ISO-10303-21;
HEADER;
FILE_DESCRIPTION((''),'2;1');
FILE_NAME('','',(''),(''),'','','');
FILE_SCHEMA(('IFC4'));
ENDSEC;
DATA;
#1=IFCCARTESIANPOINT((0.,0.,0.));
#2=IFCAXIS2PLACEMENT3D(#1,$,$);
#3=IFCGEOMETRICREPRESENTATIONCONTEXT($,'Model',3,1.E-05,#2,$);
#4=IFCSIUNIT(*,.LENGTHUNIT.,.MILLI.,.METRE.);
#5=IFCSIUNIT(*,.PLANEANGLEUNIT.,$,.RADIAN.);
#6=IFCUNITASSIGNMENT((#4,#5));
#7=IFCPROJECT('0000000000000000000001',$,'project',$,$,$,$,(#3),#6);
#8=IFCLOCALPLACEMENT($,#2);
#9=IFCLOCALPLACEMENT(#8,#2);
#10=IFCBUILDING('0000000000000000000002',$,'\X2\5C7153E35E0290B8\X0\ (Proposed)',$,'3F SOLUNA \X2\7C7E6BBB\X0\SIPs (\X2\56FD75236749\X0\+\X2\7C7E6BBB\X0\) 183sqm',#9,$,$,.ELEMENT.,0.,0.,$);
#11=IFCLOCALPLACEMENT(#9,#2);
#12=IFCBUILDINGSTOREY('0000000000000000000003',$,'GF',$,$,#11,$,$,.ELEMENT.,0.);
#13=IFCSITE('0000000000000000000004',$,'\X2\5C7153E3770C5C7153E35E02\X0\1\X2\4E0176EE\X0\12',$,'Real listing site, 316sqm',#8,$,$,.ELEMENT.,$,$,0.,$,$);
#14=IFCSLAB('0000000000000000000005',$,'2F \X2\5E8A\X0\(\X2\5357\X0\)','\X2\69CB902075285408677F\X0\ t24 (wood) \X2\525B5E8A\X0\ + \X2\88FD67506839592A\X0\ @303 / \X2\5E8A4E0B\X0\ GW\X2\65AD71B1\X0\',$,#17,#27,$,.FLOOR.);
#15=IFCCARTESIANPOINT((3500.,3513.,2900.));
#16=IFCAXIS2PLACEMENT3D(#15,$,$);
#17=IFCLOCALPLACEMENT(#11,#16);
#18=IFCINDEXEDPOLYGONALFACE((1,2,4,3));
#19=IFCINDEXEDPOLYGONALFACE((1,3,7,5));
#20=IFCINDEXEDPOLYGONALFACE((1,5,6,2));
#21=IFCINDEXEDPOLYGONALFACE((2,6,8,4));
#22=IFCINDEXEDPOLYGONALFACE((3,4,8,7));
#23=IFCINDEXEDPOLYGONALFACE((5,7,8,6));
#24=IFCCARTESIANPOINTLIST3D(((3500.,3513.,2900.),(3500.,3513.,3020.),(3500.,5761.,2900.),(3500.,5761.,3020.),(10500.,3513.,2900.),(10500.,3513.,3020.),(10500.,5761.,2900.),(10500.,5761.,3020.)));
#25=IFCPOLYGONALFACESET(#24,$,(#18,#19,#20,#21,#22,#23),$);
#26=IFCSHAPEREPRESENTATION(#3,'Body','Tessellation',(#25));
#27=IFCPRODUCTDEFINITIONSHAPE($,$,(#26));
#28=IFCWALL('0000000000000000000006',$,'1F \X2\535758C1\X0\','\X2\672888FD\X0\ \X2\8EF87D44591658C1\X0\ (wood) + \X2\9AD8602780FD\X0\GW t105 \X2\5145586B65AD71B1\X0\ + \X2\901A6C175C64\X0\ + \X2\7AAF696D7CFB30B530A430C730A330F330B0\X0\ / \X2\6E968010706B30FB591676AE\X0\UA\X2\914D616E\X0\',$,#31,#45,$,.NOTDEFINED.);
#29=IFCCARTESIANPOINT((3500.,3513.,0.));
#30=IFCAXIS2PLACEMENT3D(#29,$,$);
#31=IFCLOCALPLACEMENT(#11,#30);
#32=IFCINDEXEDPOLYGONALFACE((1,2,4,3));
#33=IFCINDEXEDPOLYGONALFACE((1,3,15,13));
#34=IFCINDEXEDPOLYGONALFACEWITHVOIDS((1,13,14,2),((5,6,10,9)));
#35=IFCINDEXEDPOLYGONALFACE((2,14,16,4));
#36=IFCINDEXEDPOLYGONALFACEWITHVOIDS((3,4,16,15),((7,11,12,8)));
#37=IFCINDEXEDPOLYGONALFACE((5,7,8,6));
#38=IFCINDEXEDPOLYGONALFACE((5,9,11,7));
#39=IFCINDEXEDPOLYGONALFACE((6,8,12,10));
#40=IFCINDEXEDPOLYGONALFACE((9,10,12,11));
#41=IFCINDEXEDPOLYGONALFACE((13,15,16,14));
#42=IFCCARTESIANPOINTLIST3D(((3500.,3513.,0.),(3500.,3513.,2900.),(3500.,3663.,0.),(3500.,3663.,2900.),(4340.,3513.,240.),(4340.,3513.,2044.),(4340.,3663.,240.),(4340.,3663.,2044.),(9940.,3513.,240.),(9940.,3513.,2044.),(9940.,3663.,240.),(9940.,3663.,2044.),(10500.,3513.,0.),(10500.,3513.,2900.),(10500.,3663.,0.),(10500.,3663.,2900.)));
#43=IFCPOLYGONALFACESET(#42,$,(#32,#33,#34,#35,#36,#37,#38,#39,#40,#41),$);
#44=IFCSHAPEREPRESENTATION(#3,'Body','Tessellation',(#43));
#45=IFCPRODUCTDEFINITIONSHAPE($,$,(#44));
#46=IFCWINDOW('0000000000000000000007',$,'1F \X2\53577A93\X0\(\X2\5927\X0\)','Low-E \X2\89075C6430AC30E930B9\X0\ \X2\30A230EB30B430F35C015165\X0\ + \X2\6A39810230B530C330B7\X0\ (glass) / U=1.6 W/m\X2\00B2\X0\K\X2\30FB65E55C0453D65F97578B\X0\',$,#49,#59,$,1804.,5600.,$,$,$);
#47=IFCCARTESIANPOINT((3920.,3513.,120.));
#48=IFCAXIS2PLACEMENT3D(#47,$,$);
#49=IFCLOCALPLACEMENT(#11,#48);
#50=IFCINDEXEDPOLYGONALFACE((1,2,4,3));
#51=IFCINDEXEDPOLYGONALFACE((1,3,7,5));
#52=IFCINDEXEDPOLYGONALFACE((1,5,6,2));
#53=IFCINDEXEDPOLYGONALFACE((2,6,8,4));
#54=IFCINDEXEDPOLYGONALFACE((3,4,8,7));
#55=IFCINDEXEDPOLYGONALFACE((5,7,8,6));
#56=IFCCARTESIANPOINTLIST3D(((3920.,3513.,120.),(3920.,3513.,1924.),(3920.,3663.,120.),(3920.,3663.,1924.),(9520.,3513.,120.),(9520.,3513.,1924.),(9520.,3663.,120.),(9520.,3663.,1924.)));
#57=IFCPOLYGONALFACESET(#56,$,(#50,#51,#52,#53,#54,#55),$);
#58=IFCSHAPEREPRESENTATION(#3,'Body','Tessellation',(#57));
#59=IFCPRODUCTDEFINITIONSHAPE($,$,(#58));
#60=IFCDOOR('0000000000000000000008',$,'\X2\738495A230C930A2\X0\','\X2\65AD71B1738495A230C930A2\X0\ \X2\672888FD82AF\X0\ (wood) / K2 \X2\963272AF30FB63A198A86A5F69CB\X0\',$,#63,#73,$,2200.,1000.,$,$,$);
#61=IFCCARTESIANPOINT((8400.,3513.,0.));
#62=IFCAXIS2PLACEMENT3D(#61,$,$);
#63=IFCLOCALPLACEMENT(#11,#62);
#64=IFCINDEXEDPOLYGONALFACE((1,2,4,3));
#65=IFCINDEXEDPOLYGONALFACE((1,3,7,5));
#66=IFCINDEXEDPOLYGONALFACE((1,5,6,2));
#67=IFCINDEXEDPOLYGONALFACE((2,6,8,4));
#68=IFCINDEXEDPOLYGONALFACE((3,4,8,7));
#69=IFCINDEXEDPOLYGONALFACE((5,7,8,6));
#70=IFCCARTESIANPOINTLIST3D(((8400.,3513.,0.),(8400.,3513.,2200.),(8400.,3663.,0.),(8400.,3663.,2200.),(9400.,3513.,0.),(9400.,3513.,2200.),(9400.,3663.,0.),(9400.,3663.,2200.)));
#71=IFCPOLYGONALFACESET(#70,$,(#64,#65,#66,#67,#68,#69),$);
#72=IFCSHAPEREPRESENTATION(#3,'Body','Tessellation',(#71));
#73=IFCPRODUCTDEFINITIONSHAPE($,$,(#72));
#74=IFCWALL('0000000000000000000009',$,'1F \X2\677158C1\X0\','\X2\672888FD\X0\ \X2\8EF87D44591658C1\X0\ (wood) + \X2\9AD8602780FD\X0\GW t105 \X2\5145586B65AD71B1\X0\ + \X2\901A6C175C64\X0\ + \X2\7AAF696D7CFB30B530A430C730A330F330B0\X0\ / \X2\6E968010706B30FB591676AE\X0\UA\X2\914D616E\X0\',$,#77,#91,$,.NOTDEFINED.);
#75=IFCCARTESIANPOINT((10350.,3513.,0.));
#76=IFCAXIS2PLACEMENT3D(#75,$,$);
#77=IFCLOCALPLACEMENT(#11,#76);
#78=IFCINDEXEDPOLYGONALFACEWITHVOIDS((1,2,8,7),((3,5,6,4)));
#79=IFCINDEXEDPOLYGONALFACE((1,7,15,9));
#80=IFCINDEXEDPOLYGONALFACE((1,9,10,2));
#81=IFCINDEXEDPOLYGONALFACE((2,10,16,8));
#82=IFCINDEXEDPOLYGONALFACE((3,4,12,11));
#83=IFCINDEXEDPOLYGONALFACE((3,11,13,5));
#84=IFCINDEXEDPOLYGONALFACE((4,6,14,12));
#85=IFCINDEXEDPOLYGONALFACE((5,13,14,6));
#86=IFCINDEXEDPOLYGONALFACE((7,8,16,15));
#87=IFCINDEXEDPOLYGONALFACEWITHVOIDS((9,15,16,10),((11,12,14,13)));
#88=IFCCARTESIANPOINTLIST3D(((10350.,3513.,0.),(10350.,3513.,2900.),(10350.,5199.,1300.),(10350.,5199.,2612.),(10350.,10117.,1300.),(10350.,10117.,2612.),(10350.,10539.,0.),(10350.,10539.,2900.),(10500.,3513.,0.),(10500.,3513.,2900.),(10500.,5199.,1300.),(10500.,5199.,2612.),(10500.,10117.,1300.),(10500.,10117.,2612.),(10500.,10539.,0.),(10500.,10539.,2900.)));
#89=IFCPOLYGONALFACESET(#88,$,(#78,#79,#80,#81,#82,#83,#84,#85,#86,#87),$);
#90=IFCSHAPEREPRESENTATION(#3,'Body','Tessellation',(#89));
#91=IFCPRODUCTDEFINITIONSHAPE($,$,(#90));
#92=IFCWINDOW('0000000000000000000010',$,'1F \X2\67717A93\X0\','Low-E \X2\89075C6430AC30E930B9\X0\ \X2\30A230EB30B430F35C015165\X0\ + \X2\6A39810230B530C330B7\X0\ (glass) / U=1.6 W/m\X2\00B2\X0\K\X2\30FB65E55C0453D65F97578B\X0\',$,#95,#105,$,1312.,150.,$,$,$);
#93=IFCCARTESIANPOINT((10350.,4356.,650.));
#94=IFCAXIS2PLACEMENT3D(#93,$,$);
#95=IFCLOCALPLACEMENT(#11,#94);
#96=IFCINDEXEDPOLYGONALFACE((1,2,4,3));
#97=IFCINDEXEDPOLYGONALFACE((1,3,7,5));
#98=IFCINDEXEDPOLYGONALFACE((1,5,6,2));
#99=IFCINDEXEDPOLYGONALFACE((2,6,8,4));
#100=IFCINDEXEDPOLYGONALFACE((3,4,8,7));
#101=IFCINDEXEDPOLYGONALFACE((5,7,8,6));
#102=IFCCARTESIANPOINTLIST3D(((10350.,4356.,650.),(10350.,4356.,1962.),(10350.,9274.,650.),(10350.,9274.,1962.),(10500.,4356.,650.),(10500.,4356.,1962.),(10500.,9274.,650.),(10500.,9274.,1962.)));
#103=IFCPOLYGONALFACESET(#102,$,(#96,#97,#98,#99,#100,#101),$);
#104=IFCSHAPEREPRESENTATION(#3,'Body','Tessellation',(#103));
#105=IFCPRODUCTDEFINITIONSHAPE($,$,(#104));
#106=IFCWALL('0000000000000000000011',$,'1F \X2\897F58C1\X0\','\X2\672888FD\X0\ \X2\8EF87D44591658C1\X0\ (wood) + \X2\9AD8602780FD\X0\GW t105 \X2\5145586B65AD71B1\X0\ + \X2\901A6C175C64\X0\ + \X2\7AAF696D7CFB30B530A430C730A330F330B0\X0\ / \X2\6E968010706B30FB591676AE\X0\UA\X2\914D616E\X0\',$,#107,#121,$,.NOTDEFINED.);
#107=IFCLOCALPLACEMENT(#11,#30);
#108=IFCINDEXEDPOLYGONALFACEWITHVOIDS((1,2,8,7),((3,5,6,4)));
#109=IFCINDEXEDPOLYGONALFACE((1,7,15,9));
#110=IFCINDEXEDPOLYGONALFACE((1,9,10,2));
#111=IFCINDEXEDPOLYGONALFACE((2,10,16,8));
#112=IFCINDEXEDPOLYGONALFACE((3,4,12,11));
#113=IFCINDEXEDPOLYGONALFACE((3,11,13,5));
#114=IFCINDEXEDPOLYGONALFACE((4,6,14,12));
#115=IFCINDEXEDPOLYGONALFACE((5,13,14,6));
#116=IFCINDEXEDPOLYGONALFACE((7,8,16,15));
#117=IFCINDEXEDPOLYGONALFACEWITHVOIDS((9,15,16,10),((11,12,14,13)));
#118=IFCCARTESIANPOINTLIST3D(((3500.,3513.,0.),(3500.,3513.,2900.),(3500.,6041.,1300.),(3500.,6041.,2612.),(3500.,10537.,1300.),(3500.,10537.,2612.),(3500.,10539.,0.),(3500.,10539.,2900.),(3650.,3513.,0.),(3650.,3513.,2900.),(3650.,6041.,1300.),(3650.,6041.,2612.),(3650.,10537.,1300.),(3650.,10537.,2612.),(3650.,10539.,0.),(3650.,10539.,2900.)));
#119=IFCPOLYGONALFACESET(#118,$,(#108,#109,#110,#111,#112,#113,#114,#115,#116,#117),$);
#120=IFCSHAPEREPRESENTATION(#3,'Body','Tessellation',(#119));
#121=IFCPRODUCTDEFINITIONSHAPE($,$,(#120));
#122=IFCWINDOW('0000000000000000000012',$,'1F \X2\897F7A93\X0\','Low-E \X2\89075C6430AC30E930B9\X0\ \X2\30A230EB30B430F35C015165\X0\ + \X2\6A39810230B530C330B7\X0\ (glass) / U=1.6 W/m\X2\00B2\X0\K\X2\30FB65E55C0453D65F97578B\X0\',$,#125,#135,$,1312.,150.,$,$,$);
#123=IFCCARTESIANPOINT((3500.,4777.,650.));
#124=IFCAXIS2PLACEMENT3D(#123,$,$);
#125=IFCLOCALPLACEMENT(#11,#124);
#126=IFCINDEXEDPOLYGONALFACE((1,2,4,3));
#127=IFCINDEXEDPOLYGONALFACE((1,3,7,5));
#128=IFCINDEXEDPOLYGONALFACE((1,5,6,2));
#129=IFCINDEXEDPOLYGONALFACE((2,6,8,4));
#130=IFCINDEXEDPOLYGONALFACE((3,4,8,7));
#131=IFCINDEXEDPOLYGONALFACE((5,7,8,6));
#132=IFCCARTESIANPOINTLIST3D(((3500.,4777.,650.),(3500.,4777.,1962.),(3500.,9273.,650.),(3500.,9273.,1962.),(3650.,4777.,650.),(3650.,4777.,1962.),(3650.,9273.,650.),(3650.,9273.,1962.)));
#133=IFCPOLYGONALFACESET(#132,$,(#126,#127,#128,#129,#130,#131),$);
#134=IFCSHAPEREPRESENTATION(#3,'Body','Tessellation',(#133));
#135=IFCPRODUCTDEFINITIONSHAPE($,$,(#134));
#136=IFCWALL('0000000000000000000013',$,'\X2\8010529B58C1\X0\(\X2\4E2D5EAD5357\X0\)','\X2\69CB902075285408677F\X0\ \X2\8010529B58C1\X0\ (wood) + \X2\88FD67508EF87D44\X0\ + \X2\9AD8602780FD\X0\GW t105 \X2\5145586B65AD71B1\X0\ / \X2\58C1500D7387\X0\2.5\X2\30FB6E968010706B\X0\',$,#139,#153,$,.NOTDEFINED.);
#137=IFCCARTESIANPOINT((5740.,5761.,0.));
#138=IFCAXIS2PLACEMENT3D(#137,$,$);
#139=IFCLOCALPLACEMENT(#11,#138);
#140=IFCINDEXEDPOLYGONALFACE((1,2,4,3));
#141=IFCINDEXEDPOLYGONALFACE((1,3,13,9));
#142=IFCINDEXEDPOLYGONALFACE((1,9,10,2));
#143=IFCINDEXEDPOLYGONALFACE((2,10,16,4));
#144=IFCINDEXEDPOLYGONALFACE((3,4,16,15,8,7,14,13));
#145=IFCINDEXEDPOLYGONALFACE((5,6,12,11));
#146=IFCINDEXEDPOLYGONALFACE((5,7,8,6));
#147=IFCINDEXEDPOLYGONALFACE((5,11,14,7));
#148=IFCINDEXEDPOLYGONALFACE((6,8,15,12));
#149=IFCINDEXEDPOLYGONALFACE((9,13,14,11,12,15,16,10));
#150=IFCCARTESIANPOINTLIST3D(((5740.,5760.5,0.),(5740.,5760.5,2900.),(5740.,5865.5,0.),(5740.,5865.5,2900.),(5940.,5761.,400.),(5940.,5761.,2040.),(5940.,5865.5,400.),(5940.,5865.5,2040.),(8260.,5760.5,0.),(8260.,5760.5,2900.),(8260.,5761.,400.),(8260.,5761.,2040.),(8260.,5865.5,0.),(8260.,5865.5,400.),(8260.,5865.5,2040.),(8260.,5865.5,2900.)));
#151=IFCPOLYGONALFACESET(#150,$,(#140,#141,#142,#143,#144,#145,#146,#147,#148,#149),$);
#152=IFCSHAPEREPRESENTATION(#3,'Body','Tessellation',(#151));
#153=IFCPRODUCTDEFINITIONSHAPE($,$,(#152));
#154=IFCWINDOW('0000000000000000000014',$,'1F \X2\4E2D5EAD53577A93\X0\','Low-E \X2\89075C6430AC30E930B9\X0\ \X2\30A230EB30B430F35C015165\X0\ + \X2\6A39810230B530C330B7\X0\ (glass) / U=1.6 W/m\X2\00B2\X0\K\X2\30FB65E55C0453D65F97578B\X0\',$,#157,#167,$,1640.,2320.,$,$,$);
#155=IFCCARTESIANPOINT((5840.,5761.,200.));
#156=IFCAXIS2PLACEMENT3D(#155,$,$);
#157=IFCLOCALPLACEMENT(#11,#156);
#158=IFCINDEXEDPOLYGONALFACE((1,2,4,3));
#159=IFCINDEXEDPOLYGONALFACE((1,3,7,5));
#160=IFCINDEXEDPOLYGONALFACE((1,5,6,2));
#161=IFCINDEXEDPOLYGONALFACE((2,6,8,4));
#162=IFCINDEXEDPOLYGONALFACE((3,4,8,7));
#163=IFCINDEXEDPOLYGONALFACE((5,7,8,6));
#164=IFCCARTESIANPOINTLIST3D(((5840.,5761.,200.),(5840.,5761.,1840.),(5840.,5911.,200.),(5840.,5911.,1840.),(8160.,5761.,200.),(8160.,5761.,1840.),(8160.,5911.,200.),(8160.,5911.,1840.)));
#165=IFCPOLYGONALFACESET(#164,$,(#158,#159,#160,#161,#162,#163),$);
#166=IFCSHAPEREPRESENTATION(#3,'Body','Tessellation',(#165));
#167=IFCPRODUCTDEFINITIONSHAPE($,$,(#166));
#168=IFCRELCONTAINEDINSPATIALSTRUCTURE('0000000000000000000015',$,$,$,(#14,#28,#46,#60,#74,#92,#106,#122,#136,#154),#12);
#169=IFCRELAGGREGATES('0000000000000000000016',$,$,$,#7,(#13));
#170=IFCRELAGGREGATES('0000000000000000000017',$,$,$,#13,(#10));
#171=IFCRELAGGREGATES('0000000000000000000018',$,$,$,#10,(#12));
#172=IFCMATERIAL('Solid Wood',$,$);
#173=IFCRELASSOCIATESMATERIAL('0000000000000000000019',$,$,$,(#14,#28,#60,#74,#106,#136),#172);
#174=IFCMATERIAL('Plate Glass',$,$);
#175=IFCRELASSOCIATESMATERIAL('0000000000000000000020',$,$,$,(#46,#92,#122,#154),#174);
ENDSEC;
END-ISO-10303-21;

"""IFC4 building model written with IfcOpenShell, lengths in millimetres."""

from ifc_helpers import new_model, si_unit, frame, frame_2d, origin, place, context, project, spatial, rectangle, extrude, material, element, fill, save


model = new_model("IFC4")

# Units and contexts
model_context = context("Model", 3, precision=1e-05, world=origin())
ifc_project = project(units=[si_unit("LENGTHUNIT", "METRE", prefix="MILLI"), si_unit("PLANEANGLEUNIT", "RADIAN")], contexts=[model_context])

# Site, building, storey
site_placement = place(None, origin())
site = spatial("IfcSite", under=ifc_project, at=site_placement, Name="山口県山口市1丁目12", ObjectType="Real listing site, 316sqm", CompositionType="ELEMENT", RefElevation=0.0)
building_placement = place(site_placement, origin())
building = spatial("IfcBuilding", under=site, at=building_placement, Name="山口市邸 (Proposed)", ObjectType="3F SOLUNA 籾殻SIPs (国産杉+籾殻) 183sqm", CompositionType="ELEMENT", ElevationOfRefHeight=0.0, ElevationOfTerrain=0.0)
storey_placement = place(building_placement, origin())
storey = spatial("IfcBuildingStorey", under=building, at=storey_placement, Name="GF", CompositionType="ELEMENT", Elevation=0.0)

# Slab
ifc_material_1 = material(Name="Solid Wood")
slab_1_placement = place(storey_placement, frame((3500.0, 3513.0, 2900.0)))
element("IfcSlab", 1, at=slab_1_placement, inside=storey, material=ifc_material_1, Name="2F 床(南)", Description="構造用合板 t24 (wood) 剛床 + 製材根太 @303 / 床下 GW断熱", PredefinedType="FLOOR", context=model_context, shape_type="SweptSolid", body=[
    extrude(rectangle(XDim=7000.0, YDim=2248.0, at=frame_2d((3500.0, 1124.0))), frame((3500.0, 3513.0, 2900.0)), (0.0, 0.0, 1.0), 120.0),
])

# Wall, openings, window, door
wall_1_placement = place(storey_placement, frame((3500.0, 3513.0, 0.0)))
wall_1 = element("IfcWall", 2, at=wall_1_placement, inside=storey, material=ifc_material_1, Name="1F 南壁", Description="木製 軸組外壁 (wood) + 高性能GW t105 充填断熱 + 通気層 + 窯業系サイディング / 準耐火・外皮UA配慮", PredefinedType="NOTDEFINED", context=model_context, shape_type="SweptSolid", body=[
    extrude(rectangle(XDim=7000.0, YDim=150.0, at=frame_2d((3500.0, 75.0))), frame((3500.0, 3513.0, 0.0)), (0.0, 0.0, 1.0), 2900.0),
])
opening_1_placement = place(storey_placement, frame((3920.0, 3513.0, 120.0)))
opening_1 = element("IfcOpeningElement", 3, at=opening_1_placement, cuts=wall_1, PredefinedType="NOTDEFINED", context=model_context, shape_type="SweptSolid", body=[
    extrude(rectangle(XDim=5600.0, YDim=150.0, at=frame_2d((2800.0, 75.0))), frame((3920.0, 3513.0, 120.0)), (0.0, 0.0, 1.0), 1804.0),
])
opening_2_placement = place(storey_placement, frame((8400.0, 3513.0, 0.0)))
opening_2 = element("IfcOpeningElement", 4, at=opening_2_placement, cuts=wall_1, PredefinedType="NOTDEFINED", context=model_context, shape_type="SweptSolid", body=[
    extrude(rectangle(XDim=1000.0, YDim=150.0, at=frame_2d((500.0, 75.0))), frame((8400.0, 3513.0, 0.0)), (0.0, 0.0, 1.0), 2200.0),
])
ifc_material_2 = material(Name="Plate Glass")
window_1_placement = place(storey_placement, frame((3920.0, 3513.0, 120.0)))
window_1 = element("IfcWindow", 5, at=window_1_placement, inside=storey, material=ifc_material_2, Name="1F 南窓(大)", Description="Low-E 複層ガラス アルゴン封入 + 樹脂サッシ (glass) / U=1.6 W/m²K・日射取得型", OverallHeight=1804.0, OverallWidth=5600.0, context=model_context, shape_type="SweptSolid", body=[
    extrude(rectangle(XDim=5600.0, YDim=150.0, at=frame_2d((2800.0, 75.0))), frame((3920.0, 3513.0, 120.0)), (0.0, 0.0, 1.0), 1804.0),
])
fill(opening_1, window_1)
door_placement = place(storey_placement, frame((8400.0, 3513.0, 0.0)))
door = element("IfcDoor", 6, at=door_placement, inside=storey, material=ifc_material_1, Name="玄関ドア", Description="断熱玄関ドア 木製芯 (wood) / K2 防犯・採風機構", OverallHeight=2200.0, OverallWidth=1000.0, context=model_context, shape_type="SweptSolid", body=[
    extrude(rectangle(XDim=1000.0, YDim=150.0, at=frame_2d((500.0, 75.0))), frame((8400.0, 3513.0, 0.0)), (0.0, 0.0, 1.0), 2200.0),
])
fill(opening_2, door)

# Walls, openings, windows
wall_2_placement = place(storey_placement, frame((10350.0, 3513.0, 0.0)))
wall_2 = element("IfcWall", 7, at=wall_2_placement, inside=storey, material=ifc_material_1, Name="1F 東壁", Description="木製 軸組外壁 (wood) + 高性能GW t105 充填断熱 + 通気層 + 窯業系サイディング / 準耐火・外皮UA配慮", PredefinedType="NOTDEFINED", context=model_context, shape_type="SweptSolid", body=[
    extrude(rectangle(XDim=150.0, YDim=7026.0, at=frame_2d((75.0, 3513.0))), frame((10350.0, 3513.0, 0.0)), (0.0, 0.0, 1.0), 2900.0),
])
opening_3_placement = place(storey_placement, frame((10350.0, 4356.0, 650.0)))
opening_3 = element("IfcOpeningElement", 8, at=opening_3_placement, cuts=wall_2, PredefinedType="NOTDEFINED", context=model_context, shape_type="SweptSolid", body=[
    extrude(rectangle(XDim=150.0, YDim=4918.0, at=frame_2d((75.0, 2459.0))), frame((10350.0, 4356.0, 650.0)), (0.0, 0.0, 1.0), 1312.0),
])
window_2_placement = place(storey_placement, frame((10350.0, 4356.0, 650.0)))
window_2 = element("IfcWindow", 9, at=window_2_placement, inside=storey, material=ifc_material_2, Name="1F 東窓", Description="Low-E 複層ガラス アルゴン封入 + 樹脂サッシ (glass) / U=1.6 W/m²K・日射取得型", OverallHeight=1312.0, OverallWidth=150.0, context=model_context, shape_type="SweptSolid", body=[
    extrude(rectangle(XDim=150.0, YDim=4918.0, at=frame_2d((75.0, 2459.0))), frame((10350.0, 4356.0, 650.0)), (0.0, 0.0, 1.0), 1312.0),
])
fill(opening_3, window_2)
wall_3_placement = place(storey_placement, frame((3500.0, 3513.0, 0.0)))
wall_3 = element("IfcWall", 10, at=wall_3_placement, inside=storey, material=ifc_material_1, Name="1F 西壁", Description="木製 軸組外壁 (wood) + 高性能GW t105 充填断熱 + 通気層 + 窯業系サイディング / 準耐火・外皮UA配慮", PredefinedType="NOTDEFINED", context=model_context, shape_type="SweptSolid", body=[
    extrude(rectangle(XDim=150.0, YDim=7026.0, at=frame_2d((75.0, 3513.0))), frame((3500.0, 3513.0, 0.0)), (0.0, 0.0, 1.0), 2900.0),
])
opening_4_placement = place(storey_placement, frame((3500.0, 4777.0, 650.0)))
opening_4 = element("IfcOpeningElement", 11, at=opening_4_placement, cuts=wall_3, PredefinedType="NOTDEFINED", context=model_context, shape_type="SweptSolid", body=[
    extrude(rectangle(XDim=150.0, YDim=4496.0, at=frame_2d((75.0, 2248.0))), frame((3500.0, 4777.0, 650.0)), (0.0, 0.0, 1.0), 1312.0),
])
window_3_placement = place(storey_placement, frame((3500.0, 4777.0, 650.0)))
window_3 = element("IfcWindow", 12, at=window_3_placement, inside=storey, material=ifc_material_2, Name="1F 西窓", Description="Low-E 複層ガラス アルゴン封入 + 樹脂サッシ (glass) / U=1.6 W/m²K・日射取得型", OverallHeight=1312.0, OverallWidth=150.0, context=model_context, shape_type="SweptSolid", body=[
    extrude(rectangle(XDim=150.0, YDim=4496.0, at=frame_2d((75.0, 2248.0))), frame((3500.0, 4777.0, 650.0)), (0.0, 0.0, 1.0), 1312.0),
])
fill(opening_4, window_3)
wall_4_placement = place(storey_placement, frame((5740.0, 5761.0, 0.0)))
wall_4 = element("IfcWall", 13, at=wall_4_placement, inside=storey, material=ifc_material_1, Name="耐力壁(中庭南)", Description="構造用合板 耐力壁 (wood) + 製材軸組 + 高性能GW t105 充填断熱 / 壁倍率2.5・準耐火", PredefinedType="NOTDEFINED", context=model_context, shape_type="SweptSolid", body=[
    extrude(rectangle(XDim=2520.0, YDim=105.0, at=frame_2d((1260.0, 52.0))), frame((5740.0, 5761.0, 0.0)), (0.0, 0.0, 1.0), 2900.0),
])
opening_5_placement = place(storey_placement, frame((5840.0, 5761.0, 200.0)))
opening_5 = element("IfcOpeningElement", 14, at=opening_5_placement, cuts=wall_4, PredefinedType="NOTDEFINED", context=model_context, shape_type="SweptSolid", body=[
    extrude(rectangle(XDim=2320.0, YDim=150.0, at=frame_2d((1160.0, 75.0))), frame((5840.0, 5761.0, 200.0)), (0.0, 0.0, 1.0), 1640.0),
])
window_4_placement = place(storey_placement, frame((5840.0, 5761.0, 200.0)))
window_4 = element("IfcWindow", 15, at=window_4_placement, inside=storey, material=ifc_material_2, Name="1F 中庭南窓", Description="Low-E 複層ガラス アルゴン封入 + 樹脂サッシ (glass) / U=1.6 W/m²K・日射取得型", OverallHeight=1640.0, OverallWidth=2320.0, context=model_context, shape_type="SweptSolid", body=[
    extrude(rectangle(XDim=2320.0, YDim=150.0, at=frame_2d((1160.0, 75.0))), frame((5840.0, 5761.0, 200.0)), (0.0, 0.0, 1.0), 1640.0),
])
fill(opening_5, window_4)

save(model, "model.ifc")
